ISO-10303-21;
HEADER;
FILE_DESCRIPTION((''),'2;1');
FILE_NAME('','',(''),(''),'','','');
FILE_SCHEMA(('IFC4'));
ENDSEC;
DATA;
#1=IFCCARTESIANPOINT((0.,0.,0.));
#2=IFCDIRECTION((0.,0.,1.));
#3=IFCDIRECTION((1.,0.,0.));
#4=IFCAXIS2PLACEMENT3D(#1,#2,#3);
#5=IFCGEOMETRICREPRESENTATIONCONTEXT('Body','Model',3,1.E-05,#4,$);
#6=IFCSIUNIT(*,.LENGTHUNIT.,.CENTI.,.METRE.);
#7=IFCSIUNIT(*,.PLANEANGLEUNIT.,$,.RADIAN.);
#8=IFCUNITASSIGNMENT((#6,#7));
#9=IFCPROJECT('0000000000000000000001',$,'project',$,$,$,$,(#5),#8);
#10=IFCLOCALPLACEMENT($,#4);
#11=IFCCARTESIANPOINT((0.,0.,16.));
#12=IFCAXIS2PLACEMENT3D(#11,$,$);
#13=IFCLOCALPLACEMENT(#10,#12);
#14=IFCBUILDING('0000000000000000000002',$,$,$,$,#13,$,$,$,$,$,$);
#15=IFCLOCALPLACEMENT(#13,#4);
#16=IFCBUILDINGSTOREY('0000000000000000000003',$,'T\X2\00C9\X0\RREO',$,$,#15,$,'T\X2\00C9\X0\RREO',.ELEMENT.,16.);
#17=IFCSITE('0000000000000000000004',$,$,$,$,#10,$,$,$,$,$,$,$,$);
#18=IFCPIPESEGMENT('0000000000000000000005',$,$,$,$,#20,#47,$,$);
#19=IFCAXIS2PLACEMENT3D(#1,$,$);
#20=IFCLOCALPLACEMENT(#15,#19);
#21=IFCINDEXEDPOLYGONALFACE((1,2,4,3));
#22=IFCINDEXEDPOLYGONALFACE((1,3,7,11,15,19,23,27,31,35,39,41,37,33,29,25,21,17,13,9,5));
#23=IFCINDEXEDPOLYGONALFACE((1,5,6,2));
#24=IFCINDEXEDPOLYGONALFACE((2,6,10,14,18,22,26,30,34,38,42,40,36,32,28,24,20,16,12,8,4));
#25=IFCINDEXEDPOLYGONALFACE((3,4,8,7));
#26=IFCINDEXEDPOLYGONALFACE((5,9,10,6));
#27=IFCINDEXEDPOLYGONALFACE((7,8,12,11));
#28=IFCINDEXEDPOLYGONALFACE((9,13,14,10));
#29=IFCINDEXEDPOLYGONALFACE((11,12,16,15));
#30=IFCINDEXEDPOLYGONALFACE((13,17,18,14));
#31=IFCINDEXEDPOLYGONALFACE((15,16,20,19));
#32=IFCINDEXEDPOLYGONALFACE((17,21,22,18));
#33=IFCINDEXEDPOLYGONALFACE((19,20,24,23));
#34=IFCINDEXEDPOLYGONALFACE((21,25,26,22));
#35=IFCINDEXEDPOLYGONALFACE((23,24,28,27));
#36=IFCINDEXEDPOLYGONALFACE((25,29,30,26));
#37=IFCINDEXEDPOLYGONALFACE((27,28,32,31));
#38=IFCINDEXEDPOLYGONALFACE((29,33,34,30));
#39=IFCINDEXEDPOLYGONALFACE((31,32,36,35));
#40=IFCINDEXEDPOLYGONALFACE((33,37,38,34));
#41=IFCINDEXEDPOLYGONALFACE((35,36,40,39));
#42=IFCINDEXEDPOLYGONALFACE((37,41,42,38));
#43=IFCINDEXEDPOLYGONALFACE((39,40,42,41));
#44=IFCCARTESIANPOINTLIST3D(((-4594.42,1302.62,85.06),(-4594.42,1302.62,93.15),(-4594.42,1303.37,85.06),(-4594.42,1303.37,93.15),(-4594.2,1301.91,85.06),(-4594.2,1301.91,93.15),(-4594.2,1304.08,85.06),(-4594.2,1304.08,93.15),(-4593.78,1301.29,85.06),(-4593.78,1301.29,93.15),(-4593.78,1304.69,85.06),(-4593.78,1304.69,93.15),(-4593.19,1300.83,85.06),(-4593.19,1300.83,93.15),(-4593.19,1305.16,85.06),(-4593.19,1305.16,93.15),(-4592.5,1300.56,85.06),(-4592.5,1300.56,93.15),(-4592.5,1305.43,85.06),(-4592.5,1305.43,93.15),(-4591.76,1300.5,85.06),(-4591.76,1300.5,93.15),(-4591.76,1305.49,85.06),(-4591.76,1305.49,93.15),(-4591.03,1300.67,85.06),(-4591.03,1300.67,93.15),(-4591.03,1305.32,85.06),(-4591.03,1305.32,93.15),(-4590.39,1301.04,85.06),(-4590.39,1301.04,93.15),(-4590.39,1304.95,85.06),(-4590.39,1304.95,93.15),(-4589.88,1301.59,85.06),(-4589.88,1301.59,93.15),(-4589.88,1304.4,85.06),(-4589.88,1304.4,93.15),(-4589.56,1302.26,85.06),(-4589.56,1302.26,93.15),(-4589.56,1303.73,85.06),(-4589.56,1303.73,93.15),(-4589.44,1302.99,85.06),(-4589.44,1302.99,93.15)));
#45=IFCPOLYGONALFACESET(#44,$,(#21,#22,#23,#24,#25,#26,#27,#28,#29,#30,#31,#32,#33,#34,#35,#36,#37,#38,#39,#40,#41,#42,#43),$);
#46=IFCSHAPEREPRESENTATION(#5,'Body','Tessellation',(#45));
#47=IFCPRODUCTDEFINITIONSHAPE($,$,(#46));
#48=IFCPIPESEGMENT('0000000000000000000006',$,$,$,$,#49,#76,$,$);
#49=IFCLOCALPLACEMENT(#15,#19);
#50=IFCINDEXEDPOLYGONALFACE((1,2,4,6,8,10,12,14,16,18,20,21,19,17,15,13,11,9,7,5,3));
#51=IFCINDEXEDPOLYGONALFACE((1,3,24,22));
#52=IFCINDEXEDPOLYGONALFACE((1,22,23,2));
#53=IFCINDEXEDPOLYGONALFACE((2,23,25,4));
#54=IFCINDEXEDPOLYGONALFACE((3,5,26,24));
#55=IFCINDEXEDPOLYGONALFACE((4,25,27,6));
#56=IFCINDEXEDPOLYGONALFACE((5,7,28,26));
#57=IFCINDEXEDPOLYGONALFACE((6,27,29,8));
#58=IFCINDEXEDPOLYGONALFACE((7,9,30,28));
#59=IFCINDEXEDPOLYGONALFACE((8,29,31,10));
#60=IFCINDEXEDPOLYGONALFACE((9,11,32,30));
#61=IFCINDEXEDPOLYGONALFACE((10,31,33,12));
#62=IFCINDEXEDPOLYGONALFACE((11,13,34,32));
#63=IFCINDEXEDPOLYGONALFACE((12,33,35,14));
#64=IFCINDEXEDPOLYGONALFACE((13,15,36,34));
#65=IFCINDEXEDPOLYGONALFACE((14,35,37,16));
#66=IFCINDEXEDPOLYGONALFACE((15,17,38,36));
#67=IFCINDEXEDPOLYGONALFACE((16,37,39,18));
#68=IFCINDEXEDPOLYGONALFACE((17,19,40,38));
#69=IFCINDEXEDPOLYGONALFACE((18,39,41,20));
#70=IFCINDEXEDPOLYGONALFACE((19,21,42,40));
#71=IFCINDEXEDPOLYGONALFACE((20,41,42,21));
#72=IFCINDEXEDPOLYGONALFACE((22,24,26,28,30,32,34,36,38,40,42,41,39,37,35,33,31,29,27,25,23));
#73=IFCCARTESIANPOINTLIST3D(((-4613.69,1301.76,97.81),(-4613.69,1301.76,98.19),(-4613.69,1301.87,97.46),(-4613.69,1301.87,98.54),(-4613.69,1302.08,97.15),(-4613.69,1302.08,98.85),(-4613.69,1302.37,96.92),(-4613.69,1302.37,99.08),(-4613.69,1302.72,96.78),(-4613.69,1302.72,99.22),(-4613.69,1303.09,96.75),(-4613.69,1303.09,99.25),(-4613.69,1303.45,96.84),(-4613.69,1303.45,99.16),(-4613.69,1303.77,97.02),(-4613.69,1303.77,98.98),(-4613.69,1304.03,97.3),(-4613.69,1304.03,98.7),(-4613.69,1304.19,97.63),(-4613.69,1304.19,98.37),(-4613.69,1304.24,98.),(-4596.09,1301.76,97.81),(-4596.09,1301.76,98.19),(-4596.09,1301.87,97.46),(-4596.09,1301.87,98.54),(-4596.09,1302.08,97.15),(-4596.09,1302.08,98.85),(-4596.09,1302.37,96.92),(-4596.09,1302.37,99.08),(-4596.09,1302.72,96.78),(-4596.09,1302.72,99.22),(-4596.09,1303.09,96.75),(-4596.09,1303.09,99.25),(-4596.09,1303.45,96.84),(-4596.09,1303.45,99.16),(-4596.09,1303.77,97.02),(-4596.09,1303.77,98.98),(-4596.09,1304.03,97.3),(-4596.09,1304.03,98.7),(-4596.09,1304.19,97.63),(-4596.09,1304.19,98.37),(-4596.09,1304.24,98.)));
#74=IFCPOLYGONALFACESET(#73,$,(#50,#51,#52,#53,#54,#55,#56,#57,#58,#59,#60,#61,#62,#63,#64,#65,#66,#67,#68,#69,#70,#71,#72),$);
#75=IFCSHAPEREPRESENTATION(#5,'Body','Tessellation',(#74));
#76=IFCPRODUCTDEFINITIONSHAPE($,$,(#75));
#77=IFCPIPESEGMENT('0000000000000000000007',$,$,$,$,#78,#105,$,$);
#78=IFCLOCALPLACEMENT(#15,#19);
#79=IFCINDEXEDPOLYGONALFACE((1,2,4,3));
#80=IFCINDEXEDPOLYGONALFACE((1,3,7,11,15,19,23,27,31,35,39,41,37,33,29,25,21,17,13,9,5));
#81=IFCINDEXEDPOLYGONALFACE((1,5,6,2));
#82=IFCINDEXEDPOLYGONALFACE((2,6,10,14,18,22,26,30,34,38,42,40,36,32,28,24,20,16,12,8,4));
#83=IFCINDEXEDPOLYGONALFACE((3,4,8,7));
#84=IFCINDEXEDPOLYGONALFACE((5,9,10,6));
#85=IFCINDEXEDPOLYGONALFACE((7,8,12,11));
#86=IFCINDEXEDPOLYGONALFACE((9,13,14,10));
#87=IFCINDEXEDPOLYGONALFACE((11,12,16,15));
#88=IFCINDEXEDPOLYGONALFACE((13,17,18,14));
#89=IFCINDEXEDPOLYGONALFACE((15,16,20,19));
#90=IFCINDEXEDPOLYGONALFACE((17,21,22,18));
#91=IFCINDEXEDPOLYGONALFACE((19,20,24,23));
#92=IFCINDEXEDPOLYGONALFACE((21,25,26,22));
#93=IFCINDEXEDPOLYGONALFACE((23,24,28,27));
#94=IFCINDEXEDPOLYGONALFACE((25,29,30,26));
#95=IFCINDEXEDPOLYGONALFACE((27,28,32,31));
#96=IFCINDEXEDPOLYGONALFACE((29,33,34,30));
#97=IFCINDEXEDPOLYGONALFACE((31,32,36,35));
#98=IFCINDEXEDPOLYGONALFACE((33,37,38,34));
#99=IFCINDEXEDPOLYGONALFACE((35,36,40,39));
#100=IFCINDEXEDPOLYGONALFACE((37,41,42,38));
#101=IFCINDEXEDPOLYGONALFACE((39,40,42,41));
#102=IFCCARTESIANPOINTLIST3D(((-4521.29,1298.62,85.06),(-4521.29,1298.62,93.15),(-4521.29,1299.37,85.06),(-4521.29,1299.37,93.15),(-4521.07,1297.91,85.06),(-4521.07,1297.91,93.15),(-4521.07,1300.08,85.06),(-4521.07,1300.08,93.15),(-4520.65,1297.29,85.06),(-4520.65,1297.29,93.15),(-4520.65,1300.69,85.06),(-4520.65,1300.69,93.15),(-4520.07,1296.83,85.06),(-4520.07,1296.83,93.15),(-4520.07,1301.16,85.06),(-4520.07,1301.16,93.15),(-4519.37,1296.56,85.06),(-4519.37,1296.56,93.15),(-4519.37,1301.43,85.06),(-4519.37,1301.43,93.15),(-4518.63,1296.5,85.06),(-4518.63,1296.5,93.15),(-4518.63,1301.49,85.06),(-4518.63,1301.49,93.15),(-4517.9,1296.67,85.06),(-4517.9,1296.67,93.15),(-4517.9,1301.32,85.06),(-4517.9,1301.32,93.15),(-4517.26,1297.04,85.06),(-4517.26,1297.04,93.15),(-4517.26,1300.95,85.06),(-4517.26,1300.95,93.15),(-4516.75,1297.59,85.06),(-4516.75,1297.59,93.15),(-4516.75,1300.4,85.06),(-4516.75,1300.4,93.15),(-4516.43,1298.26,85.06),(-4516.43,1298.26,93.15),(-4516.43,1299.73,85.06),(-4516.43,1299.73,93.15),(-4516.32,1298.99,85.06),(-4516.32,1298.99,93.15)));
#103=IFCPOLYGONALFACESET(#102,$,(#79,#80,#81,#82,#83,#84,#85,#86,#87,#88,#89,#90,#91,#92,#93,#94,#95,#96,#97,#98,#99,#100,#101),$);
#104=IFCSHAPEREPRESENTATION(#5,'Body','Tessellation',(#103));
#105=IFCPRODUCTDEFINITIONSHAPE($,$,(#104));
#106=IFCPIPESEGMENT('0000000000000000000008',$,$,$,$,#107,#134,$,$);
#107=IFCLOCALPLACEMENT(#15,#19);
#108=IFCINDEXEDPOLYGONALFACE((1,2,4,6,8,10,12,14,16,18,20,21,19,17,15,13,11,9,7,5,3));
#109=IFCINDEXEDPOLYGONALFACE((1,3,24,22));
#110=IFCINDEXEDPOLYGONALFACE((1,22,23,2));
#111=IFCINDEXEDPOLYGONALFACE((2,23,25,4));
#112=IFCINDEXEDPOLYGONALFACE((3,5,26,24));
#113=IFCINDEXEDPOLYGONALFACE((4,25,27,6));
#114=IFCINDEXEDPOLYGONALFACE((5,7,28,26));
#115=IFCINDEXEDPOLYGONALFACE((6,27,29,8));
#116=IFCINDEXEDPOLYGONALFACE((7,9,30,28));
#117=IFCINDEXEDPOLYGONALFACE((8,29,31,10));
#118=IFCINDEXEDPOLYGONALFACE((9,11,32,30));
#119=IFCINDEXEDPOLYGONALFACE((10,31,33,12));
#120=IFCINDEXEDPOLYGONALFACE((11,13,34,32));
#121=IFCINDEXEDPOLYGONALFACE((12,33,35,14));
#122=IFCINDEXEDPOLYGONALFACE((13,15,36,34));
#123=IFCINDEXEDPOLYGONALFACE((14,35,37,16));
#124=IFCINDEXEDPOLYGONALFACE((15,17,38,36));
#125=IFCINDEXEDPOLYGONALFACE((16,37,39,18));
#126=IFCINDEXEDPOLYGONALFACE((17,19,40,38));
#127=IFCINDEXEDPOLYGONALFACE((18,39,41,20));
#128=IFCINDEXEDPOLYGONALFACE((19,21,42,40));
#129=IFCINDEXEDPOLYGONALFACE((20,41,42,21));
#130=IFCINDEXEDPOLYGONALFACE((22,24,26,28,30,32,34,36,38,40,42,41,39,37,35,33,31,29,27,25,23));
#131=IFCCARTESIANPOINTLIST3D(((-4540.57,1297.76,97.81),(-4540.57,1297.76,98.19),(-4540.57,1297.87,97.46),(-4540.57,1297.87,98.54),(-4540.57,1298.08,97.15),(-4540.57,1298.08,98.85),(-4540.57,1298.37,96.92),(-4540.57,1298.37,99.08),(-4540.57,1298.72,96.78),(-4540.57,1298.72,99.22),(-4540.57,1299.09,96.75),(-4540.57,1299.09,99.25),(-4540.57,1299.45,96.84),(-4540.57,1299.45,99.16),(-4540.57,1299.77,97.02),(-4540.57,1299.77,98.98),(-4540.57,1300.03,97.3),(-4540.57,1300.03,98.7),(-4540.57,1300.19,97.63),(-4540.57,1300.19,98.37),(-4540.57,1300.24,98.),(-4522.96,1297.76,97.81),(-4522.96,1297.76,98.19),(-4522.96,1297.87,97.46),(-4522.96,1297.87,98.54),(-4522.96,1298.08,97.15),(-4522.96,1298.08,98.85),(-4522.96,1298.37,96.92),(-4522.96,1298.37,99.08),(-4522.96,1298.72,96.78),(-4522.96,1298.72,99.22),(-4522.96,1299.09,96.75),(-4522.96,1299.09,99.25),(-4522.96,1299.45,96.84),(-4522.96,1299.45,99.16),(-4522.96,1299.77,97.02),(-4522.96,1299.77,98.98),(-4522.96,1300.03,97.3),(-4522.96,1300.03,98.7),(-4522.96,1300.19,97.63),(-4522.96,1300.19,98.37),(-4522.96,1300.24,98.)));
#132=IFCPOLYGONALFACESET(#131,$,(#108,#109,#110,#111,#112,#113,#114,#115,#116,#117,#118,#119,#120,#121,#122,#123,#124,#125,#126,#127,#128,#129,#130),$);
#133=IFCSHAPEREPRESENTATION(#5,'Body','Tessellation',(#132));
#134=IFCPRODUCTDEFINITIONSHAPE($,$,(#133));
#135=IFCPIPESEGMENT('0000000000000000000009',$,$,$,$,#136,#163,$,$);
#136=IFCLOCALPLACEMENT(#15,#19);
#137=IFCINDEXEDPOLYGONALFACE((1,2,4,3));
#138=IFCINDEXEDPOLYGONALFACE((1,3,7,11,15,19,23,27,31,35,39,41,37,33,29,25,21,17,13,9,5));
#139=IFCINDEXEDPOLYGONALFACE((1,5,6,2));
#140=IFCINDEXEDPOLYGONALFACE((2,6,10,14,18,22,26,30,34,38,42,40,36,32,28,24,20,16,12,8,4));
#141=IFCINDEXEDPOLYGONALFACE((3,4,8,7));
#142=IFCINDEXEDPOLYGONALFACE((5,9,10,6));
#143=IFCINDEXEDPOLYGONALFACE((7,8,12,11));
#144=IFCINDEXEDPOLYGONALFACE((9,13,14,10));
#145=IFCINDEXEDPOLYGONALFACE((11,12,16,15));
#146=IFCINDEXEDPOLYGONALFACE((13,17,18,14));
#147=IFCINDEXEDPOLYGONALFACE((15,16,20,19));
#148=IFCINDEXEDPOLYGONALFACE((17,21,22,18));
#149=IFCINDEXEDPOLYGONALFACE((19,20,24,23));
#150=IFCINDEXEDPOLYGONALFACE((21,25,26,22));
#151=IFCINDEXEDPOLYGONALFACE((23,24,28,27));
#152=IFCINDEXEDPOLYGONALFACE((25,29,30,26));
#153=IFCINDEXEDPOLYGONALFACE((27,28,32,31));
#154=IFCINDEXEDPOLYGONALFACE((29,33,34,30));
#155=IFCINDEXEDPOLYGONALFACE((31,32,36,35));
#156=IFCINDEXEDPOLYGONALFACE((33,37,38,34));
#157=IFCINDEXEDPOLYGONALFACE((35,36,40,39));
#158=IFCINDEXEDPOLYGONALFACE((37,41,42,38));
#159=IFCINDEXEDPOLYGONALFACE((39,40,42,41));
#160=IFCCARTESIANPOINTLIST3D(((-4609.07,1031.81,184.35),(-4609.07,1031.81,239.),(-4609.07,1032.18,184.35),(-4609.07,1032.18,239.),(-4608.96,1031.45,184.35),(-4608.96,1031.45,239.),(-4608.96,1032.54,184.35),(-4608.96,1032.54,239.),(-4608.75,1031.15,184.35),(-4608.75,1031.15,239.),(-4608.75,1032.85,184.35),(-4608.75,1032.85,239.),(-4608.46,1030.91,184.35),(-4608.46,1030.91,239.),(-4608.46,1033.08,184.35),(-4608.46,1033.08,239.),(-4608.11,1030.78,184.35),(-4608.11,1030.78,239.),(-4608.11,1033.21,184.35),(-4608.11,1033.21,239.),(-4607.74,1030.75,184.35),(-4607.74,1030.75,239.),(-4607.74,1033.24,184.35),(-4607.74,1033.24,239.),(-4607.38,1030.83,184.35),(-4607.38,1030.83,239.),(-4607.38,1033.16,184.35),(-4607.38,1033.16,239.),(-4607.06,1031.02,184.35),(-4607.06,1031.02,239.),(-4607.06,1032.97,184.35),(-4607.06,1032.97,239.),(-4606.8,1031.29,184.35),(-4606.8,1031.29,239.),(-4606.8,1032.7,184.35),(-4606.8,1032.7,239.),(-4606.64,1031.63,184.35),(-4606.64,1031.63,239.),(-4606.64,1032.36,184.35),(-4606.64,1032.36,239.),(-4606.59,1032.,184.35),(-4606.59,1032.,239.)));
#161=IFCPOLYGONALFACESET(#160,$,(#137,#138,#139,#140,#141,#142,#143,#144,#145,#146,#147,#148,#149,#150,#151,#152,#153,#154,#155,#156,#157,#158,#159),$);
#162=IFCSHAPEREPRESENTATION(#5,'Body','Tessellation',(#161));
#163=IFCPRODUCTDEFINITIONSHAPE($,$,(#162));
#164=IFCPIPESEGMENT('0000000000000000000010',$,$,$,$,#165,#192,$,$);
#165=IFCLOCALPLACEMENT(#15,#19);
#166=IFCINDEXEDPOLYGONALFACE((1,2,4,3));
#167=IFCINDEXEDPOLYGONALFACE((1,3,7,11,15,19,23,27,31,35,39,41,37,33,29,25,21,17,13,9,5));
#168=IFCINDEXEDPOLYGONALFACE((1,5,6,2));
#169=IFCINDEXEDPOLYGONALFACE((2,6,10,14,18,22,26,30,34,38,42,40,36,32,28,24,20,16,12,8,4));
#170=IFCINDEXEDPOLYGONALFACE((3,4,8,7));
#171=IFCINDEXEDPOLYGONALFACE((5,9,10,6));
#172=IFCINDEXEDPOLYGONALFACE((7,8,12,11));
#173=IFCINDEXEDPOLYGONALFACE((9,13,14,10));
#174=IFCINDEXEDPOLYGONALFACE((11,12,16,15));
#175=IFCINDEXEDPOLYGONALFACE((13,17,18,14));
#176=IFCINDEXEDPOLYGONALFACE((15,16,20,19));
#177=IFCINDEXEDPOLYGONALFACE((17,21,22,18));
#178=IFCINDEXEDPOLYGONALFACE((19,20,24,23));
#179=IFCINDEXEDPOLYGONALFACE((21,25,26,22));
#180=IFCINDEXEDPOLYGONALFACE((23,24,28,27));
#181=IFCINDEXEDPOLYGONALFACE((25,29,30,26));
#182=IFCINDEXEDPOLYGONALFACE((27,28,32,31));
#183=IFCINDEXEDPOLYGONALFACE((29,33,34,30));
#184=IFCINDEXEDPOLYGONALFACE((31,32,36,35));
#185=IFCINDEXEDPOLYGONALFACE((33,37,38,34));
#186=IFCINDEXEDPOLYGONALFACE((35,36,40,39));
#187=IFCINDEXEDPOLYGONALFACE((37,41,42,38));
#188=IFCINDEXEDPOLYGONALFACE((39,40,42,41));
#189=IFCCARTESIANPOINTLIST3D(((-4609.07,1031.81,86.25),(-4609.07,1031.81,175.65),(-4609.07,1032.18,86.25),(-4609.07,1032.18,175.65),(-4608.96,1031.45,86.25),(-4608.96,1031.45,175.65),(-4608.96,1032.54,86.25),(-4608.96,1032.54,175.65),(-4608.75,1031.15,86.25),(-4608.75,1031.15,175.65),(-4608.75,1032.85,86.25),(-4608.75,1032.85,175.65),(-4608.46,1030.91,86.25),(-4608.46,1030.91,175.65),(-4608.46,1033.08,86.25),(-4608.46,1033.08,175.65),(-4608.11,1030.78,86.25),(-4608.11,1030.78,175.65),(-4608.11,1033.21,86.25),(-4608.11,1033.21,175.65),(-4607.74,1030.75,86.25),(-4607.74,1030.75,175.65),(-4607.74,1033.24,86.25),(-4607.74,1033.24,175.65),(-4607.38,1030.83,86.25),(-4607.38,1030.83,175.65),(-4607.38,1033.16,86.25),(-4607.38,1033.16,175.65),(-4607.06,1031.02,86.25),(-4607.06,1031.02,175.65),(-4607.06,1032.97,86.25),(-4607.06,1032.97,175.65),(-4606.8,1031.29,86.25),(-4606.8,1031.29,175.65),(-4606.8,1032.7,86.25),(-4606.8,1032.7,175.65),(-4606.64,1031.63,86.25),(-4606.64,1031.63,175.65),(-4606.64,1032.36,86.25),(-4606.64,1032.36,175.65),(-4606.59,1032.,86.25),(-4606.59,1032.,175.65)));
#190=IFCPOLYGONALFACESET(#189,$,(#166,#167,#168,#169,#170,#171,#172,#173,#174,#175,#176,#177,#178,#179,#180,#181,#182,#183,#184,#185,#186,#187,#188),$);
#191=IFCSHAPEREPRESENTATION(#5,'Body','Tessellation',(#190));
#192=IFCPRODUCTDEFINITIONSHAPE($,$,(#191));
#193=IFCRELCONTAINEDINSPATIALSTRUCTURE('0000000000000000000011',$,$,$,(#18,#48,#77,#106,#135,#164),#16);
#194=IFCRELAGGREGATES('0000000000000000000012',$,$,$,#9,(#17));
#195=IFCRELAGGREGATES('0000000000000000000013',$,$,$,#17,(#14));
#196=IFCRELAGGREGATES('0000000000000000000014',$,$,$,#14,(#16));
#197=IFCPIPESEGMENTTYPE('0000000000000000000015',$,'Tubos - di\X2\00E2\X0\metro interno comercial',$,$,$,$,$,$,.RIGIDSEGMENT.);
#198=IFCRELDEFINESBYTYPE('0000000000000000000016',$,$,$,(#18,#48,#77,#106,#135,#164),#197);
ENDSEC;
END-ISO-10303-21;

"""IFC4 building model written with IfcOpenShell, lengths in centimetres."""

from ifc_helpers import new_model, si_unit, frame, origin_with_axes, origin_2d_with_axis, place, context, project, spatial, circle, extrude, type_object, element, save


model = new_model("IFC4")

# Units and contexts
model_context = context("Model", 3, precision=1e-05, world=origin_with_axes(), identifier="Body")
ifc_project = project(units=[si_unit("LENGTHUNIT", "METRE", prefix="CENTI"), si_unit("PLANEANGLEUNIT", "RADIAN")], contexts=[model_context])

# Site, building, storey
site_placement = place(None, origin_with_axes())
site = spatial("IfcSite", under=ifc_project, at=site_placement)
building_placement = place(site_placement, frame((0.0, 0.0, 16.0)))
building = spatial("IfcBuilding", under=site, at=building_placement)
storey_placement = place(building_placement, origin_with_axes())
storey = spatial("IfcBuildingStorey", under=building, at=storey_placement, Name="TÉRREO", LongName="TÉRREO", CompositionType="ELEMENT", Elevation=16.0)

# Pipe segments
pipe_segment_type = type_object("IfcPipeSegmentType", Name="Tubos - diâmetro interno comercial", PredefinedType="RIGIDSEGMENT")
pipe_segment_1_placement = place(storey_placement, frame((-4591.94, 1302.99, 93.15), z_axis=(0.0, 0.0, 1.0), x_axis=(1.0, 0.0, 0.0)))
element("IfcPipeSegment", 1, at=pipe_segment_1_placement, inside=storey, type_object=pipe_segment_type, context=model_context, shape_type="SolidModel", body=[
    extrude(circle(Radius=2.5, at=origin_2d_with_axis()), frame((0.0, 0.0, 0.0), z_axis=(0.0, 0.0, -1.0), x_axis=(1.0, 0.0, 0.0)), (0.0, 0.0, 1.0), 8.09),
])
pipe_segment_2_placement = place(storey_placement, frame((-4604.89, 1302.99, 99.25), z_axis=(0.0, 0.0, 1.0), x_axis=(1.0, 0.0, 0.0)))
element("IfcPipeSegment", 2, at=pipe_segment_2_placement, inside=storey, type_object=pipe_segment_type, context=model_context, shape_type="SolidModel", body=[
    extrude(circle(Radius=1.25, at=origin_2d_with_axis()), frame((8.8, 0.0, -1.25), z_axis=(-1.0, 0.0, 0.0), x_axis=(0.0, 1.0, 0.0)), (0.0, 0.0, 1.0), 17.6),
])
pipe_segment_3_placement = place(storey_placement, frame((-4518.82, 1298.99, 93.15), z_axis=(0.0, 0.0, 1.0), x_axis=(1.0, 0.0, 0.0)))
element("IfcPipeSegment", 3, at=pipe_segment_3_placement, inside=storey, type_object=pipe_segment_type, context=model_context, shape_type="SolidModel", body=[
    extrude(circle(Radius=2.5, at=origin_2d_with_axis()), frame((0.0, 0.0, 0.0), z_axis=(0.0, 0.0, -1.0), x_axis=(1.0, 0.0, 0.0)), (0.0, 0.0, 1.0), 8.09),
])
pipe_segment_4_placement = place(storey_placement, frame((-4531.77, 1298.99, 99.25), z_axis=(0.0, 0.0, 1.0), x_axis=(1.0, 0.0, 0.0)))
element("IfcPipeSegment", 4, at=pipe_segment_4_placement, inside=storey, type_object=pipe_segment_type, context=model_context, shape_type="SolidModel", body=[
    extrude(circle(Radius=1.25, at=origin_2d_with_axis()), frame((8.8, 0.0, -1.25), z_axis=(-1.0, 0.0, 0.0), x_axis=(0.0, 1.0, 0.0)), (0.0, 0.0, 1.0), 17.6),
])
pipe_segment_5_placement = place(storey_placement, frame((-4607.84, 1032.0, 239.0), z_axis=(0.0, 0.0, 1.0), x_axis=(1.0, 0.0, 0.0)))
element("IfcPipeSegment", 5, at=pipe_segment_5_placement, inside=storey, type_object=pipe_segment_type, context=model_context, shape_type="SolidModel", body=[
    extrude(circle(Radius=1.25, at=origin_2d_with_axis()), frame((0.0, 0.0, 0.0), z_axis=(0.0, 0.0, -1.0), x_axis=(1.0, 0.0, 0.0)), (0.0, 0.0, 1.0), 54.65),
])
pipe_segment_6_placement = place(storey_placement, frame((-4607.84, 1032.0, 175.65), z_axis=(0.0, 0.0, 1.0), x_axis=(1.0, 0.0, 0.0)))
element("IfcPipeSegment", 6, at=pipe_segment_6_placement, inside=storey, type_object=pipe_segment_type, context=model_context, shape_type="SolidModel", body=[
    extrude(circle(Radius=1.25, at=origin_2d_with_axis()), frame((0.0, 0.0, 0.0), z_axis=(0.0, 0.0, -1.0), x_axis=(1.0, 0.0, 0.0)), (0.0, 0.0, 1.0), 89.4),
])

save(model, "model.ifc")
